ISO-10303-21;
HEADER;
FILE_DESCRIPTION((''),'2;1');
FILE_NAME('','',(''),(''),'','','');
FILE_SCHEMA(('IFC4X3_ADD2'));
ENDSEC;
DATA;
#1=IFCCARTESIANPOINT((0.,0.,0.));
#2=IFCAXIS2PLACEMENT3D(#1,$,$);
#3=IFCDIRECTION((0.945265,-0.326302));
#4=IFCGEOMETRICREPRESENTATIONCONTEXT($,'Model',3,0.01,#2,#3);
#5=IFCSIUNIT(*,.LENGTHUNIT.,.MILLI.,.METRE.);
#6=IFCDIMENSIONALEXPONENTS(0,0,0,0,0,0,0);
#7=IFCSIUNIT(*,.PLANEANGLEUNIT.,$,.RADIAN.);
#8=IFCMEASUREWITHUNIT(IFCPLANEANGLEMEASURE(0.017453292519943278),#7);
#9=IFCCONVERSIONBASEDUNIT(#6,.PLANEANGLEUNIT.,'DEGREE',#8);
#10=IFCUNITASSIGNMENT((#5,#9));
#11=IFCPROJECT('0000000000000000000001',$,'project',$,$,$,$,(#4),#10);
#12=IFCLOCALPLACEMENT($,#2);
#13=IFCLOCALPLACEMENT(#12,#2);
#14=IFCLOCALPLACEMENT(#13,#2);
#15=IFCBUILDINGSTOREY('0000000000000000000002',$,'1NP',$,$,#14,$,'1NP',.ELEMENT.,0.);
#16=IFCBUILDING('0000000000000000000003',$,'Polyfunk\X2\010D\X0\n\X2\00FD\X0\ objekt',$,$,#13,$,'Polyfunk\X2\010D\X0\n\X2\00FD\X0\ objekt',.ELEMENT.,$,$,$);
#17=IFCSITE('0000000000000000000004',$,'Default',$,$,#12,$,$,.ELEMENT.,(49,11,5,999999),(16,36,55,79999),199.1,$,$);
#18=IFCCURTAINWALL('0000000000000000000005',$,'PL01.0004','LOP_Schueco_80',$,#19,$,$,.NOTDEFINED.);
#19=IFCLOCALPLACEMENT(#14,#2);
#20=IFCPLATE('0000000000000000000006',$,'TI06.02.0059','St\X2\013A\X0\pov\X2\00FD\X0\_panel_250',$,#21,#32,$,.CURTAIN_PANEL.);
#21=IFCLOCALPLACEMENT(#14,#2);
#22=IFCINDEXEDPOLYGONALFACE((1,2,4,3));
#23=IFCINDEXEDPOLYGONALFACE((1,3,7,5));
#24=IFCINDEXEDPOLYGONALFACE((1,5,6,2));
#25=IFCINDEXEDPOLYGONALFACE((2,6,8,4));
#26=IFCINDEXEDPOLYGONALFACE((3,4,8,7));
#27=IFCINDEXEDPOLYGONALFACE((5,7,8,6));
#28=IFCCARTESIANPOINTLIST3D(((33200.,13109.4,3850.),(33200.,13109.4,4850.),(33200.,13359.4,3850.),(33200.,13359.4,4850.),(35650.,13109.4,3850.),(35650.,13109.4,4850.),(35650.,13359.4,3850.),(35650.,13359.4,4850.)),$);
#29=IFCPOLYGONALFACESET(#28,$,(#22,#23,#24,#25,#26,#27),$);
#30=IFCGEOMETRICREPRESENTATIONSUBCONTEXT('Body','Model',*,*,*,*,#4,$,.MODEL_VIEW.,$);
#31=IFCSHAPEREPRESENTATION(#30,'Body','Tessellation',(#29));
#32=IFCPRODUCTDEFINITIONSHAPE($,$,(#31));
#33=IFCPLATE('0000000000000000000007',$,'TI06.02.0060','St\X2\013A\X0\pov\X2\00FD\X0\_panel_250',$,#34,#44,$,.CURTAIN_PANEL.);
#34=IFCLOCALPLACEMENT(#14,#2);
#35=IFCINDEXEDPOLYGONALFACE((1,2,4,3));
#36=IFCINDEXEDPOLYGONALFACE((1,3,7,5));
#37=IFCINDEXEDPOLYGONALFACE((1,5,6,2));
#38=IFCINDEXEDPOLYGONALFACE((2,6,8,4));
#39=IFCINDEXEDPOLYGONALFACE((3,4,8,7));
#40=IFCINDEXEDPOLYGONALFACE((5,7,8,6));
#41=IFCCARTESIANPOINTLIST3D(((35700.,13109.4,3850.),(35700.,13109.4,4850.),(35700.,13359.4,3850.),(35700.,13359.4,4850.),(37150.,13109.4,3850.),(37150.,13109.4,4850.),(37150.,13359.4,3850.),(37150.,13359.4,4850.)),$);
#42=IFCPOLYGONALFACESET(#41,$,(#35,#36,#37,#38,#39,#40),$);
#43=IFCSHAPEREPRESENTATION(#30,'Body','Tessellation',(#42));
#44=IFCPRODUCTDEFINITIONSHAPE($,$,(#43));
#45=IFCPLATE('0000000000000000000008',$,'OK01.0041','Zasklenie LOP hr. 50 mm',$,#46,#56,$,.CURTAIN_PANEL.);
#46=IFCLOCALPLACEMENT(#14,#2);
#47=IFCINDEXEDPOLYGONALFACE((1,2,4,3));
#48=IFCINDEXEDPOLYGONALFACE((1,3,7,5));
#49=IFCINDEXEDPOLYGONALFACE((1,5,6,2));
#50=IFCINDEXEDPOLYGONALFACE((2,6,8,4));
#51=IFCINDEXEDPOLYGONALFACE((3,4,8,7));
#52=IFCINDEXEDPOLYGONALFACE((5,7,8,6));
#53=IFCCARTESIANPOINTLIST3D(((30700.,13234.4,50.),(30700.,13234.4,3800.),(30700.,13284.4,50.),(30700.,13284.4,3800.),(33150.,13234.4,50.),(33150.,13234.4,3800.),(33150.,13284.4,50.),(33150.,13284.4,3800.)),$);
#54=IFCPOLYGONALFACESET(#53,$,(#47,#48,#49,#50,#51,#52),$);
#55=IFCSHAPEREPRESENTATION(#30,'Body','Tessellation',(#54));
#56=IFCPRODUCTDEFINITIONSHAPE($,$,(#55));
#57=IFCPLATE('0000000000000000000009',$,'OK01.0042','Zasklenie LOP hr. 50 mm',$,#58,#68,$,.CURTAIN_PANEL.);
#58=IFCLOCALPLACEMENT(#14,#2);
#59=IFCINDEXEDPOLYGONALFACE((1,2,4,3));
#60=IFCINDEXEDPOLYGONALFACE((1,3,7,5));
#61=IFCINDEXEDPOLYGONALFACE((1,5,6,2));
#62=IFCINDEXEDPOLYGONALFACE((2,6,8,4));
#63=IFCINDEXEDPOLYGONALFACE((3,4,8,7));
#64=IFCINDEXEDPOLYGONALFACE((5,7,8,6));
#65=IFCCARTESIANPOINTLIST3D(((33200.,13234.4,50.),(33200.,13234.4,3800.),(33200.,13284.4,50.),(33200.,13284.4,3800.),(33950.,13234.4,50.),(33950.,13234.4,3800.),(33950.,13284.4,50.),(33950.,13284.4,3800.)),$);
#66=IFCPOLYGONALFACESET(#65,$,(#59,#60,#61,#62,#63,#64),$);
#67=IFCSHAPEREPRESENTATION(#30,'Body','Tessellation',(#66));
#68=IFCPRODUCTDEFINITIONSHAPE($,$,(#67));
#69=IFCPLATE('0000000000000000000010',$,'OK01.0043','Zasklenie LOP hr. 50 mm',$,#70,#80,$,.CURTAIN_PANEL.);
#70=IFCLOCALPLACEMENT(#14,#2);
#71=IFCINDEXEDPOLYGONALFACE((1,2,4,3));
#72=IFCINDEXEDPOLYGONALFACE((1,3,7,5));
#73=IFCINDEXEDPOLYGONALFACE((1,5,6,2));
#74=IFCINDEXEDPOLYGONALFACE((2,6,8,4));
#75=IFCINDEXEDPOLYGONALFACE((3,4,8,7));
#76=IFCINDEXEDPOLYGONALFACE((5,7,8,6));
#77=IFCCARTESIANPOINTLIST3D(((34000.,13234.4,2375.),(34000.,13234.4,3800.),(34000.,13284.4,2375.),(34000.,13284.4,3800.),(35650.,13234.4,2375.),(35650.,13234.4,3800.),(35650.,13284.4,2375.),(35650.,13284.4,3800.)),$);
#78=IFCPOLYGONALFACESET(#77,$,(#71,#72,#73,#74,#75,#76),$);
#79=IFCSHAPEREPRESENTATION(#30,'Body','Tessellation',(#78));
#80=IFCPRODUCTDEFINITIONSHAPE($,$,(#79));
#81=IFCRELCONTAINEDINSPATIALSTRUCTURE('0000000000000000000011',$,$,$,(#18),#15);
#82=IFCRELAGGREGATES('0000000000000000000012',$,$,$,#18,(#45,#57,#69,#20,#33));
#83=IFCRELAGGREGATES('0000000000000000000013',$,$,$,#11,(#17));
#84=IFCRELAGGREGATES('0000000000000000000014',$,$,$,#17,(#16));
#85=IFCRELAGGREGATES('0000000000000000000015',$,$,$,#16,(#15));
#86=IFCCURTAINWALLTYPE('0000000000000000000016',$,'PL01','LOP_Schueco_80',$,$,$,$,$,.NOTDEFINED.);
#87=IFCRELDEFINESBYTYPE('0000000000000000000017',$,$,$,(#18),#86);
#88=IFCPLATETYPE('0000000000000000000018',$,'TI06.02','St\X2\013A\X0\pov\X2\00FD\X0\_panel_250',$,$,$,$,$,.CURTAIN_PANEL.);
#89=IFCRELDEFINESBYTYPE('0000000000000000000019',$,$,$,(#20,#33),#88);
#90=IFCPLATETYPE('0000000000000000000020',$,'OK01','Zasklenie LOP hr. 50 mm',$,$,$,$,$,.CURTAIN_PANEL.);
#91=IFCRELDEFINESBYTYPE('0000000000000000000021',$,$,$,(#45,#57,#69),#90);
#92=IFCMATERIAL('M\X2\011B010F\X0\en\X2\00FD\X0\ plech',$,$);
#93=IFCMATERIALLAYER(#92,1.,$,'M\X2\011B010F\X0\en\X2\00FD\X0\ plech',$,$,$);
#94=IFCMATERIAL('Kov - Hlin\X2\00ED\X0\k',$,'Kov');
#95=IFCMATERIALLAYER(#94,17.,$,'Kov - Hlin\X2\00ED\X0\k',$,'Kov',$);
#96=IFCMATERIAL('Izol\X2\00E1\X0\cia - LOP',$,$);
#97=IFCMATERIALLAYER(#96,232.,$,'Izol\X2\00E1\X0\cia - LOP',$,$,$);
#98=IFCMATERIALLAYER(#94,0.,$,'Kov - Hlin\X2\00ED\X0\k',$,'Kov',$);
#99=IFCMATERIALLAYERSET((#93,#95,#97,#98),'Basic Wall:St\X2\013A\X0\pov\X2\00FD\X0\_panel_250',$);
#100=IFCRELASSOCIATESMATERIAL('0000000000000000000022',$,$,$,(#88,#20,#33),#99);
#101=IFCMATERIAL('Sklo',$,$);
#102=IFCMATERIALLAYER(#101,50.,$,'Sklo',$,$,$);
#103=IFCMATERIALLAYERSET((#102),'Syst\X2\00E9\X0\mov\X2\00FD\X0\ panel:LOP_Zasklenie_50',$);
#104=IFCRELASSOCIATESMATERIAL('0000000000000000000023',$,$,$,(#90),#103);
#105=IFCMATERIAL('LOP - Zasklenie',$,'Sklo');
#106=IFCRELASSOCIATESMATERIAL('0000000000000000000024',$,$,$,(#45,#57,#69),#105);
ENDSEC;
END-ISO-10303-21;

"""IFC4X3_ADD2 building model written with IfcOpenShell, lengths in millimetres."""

from ifc_helpers import new_model, entity, si_unit, converted_unit, direction, frame, frame_2d, origin, origin_2d_with_axis, place, context, subcontext, project, spatial, rectangle, extrude, source, transform, mapped, material, layer, layer_set, layer_usage, type_object, type_shapes, element, aggregate, save


model = new_model("IFC4X3_ADD2")

# Units and contexts
model_context = context("Model", 3, precision=0.01, world=origin(), true_north=direction((0.945265, -0.326302)))
body_context = subcontext(model_context, "Body", "Model", "MODEL_VIEW")
ifc_project = project(units=[si_unit("LENGTHUNIT", "METRE", prefix="MILLI"), converted_unit("PLANEANGLEUNIT", "DEGREE", entity("IfcPlaneAngleMeasure", 0.017453292519943278), si_unit("PLANEANGLEUNIT", "RADIAN"), dimensions=[0, 0, 0, 0, 0, 0, 0])], contexts=[model_context])

# Site, building, storey
site_placement = place(None, origin())
site = spatial("IfcSite", under=ifc_project, at=site_placement, Name="Default", CompositionType="ELEMENT", RefLatitude=(49, 11, 5, 999999), RefLongitude=(16, 36, 55, 79999), RefElevation=199.1)
building_placement = place(site_placement, origin())
building = spatial("IfcBuilding", under=site, at=building_placement, Name="Polyfunkčný objekt", LongName="Polyfunkčný objekt", CompositionType="ELEMENT")
storey_placement = place(building_placement, origin())
storey = spatial("IfcBuildingStorey", under=building, at=storey_placement, Name="1NP", LongName="1NP", CompositionType="ELEMENT", Elevation=0.0)

# Curtain wall, plates
curtain_wall_type = type_object("IfcCurtainWallType", Name="PL01", Description="LOP_Schueco_80", PredefinedType="NOTDEFINED")
curtain_wall_placement = place(storey_placement, origin())
curtain_wall = element("IfcCurtainWall", 1, at=curtain_wall_placement, inside=storey, type_object=curtain_wall_type, Name="PL01.0004", Description="LOP_Schueco_80", PredefinedType="NOTDEFINED")
ifc_material_1 = material(Name="Měďený plech")
ifc_layer_1 = layer(ifc_material_1, 1.0, Name="Měďený plech")
ifc_material_2 = material(Name="Kov - Hliník", Category="Kov")
ifc_layer_2 = layer(ifc_material_2, 17.0, Name="Kov - Hliník", Category="Kov")
ifc_material_3 = material(Name="Izolácia - LOP")
ifc_layer_3 = layer(ifc_material_3, 232.0, Name="Izolácia - LOP")
ifc_layer_4 = layer(ifc_material_2, 0.0, Name="Kov - Hliník", Category="Kov")
ifc_layer_set_1 = layer_set([ifc_layer_1, ifc_layer_2, ifc_layer_3, ifc_layer_4], Name="Basic Wall:Stĺpový_panel_250")
ifc_layer_usage_1 = layer_usage(ifc_layer_set_1, "AXIS2", "NEGATIVE", 125.0)
plate_type_1 = type_object("IfcPlateType", Name="TI06.02", Description="Stĺpový_panel_250", PredefinedType="CURTAIN_PANEL", material=ifc_layer_set_1)
plate_1_placement = place(storey_placement, frame((33200.0, 13234.4, 3850.0)))
plate_1 = element("IfcPlate", 2, at=plate_1_placement, type_object=plate_type_1, material=ifc_layer_usage_1, Name="TI06.02.0059", Description="Stĺpový_panel_250", PredefinedType="CURTAIN_PANEL", context=body_context, shape_type="SweptSolid", body=[
    extrude(rectangle(XDim=250.0, YDim=2450.0, at=frame_2d((0.0, 0.0), x_axis=(1.0, 0.0))), frame((1225.0, 0.0, 0.0), z_axis=(0.0, 0.0, 1.0), x_axis=(0.0, 1.0, 0.0)), (0.0, 0.0, 1.0), 1000.0),
])
ifc_layer_usage_2 = layer_usage(ifc_layer_set_1, "AXIS2", "NEGATIVE", 125.0)
plate_2_placement = place(storey_placement, frame((35700.0, 13234.4, 3850.0)))
plate_2 = element("IfcPlate", 3, at=plate_2_placement, type_object=plate_type_1, material=ifc_layer_usage_2, Name="TI06.02.0060", Description="Stĺpový_panel_250", PredefinedType="CURTAIN_PANEL", context=body_context, shape_type="SweptSolid", body=[
    extrude(rectangle(XDim=250.0, YDim=1450.0, at=origin_2d_with_axis()), frame((725.0, 0.0, 0.0), z_axis=(0.0, 0.0, 1.0), x_axis=(0.0, 1.0, 0.0)), (0.0, 0.0, 1.0), 1000.0),
])
ifc_material_4 = material(Name="LOP - Zasklenie", Category="Sklo")
ifc_material_5 = material(Name="Sklo")
ifc_layer_5 = layer(ifc_material_5, 50.0, Name="Sklo")
ifc_layer_set_2 = layer_set([ifc_layer_5], Name="Systémový panel:LOP_Zasklenie_50")
plate_type_2 = type_object("IfcPlateType", Name="OK01", Description="Zasklenie LOP hr. 50 mm", PredefinedType="CURTAIN_PANEL", material=ifc_layer_set_2)
shared_shape_1 = source(origin(), body_context, "Body", "SweptSolid", [
    extrude(rectangle(XDim=3750.0, YDim=2450.0, at=frame_2d((-141.7, 0.0), x_axis=(1.0, 0.0))), frame((0.0, 0.0, 2016.7), z_axis=(0.0, 1.0, 0.0), x_axis=(0.0, 0.0, 1.0)), (0.0, 0.0, 1.0), 50.0),
])
plate_3_placement = place(curtain_wall_placement, frame((31925.0, 13234.4, 50.0)))
plate_3 = element("IfcPlate", 4, at=plate_3_placement, type_object=plate_type_2, material=ifc_material_4, Name="OK01.0041", Description="Zasklenie LOP hr. 50 mm", PredefinedType="CURTAIN_PANEL", context=body_context, shape_type="MappedRepresentation", body=[
    mapped(shared_shape_1, transform((0.0, 0.0, 0.0), scale=1.0)),
])
shared_shape_2 = source(origin(), body_context, "Body", "SweptSolid", [
    extrude(rectangle(XDim=3750.0, YDim=750.0, at=frame_2d((-141.7, 0.0), x_axis=(1.0, 0.0))), frame((0.0, 0.0, 2016.7), z_axis=(0.0, 1.0, 0.0), x_axis=(0.0, 0.0, 1.0)), (0.0, 0.0, 1.0), 50.0),
])
plate_4_placement = place(curtain_wall_placement, frame((33575.0, 13234.4, 50.0)))
plate_4 = element("IfcPlate", 5, at=plate_4_placement, type_object=plate_type_2, material=ifc_material_4, Name="OK01.0042", Description="Zasklenie LOP hr. 50 mm", PredefinedType="CURTAIN_PANEL", context=body_context, shape_type="MappedRepresentation", body=[
    mapped(shared_shape_2, transform((0.0, 0.0, 0.0), scale=1.0)),
])
shared_shape_3 = source(origin(), body_context, "Body", "SweptSolid", [
    extrude(rectangle(XDim=50.0, YDim=1650.0, at=origin_2d_with_axis()), frame((0.0, 25.0, 0.0), z_axis=(0.0, 0.0, 1.0), x_axis=(0.0, 1.0, 0.0)), (0.0, 0.0, 1.0), 1425.0),
])
type_shapes(plate_type_2, [shared_shape_1, shared_shape_2, shared_shape_3])
plate_5_placement = place(curtain_wall_placement, frame((34825.0, 13234.4, 2375.0)))
plate_5 = element("IfcPlate", 6, at=plate_5_placement, type_object=plate_type_2, material=ifc_material_4, Name="OK01.0043", Description="Zasklenie LOP hr. 50 mm", PredefinedType="CURTAIN_PANEL", context=body_context, shape_type="MappedRepresentation", body=[
    mapped(shared_shape_3, transform((0.0, 0.0, 0.0), scale=1.0)),
])
aggregate(curtain_wall, [plate_3, plate_4, plate_5, plate_1, plate_2])

save(model, "model.ifc")
